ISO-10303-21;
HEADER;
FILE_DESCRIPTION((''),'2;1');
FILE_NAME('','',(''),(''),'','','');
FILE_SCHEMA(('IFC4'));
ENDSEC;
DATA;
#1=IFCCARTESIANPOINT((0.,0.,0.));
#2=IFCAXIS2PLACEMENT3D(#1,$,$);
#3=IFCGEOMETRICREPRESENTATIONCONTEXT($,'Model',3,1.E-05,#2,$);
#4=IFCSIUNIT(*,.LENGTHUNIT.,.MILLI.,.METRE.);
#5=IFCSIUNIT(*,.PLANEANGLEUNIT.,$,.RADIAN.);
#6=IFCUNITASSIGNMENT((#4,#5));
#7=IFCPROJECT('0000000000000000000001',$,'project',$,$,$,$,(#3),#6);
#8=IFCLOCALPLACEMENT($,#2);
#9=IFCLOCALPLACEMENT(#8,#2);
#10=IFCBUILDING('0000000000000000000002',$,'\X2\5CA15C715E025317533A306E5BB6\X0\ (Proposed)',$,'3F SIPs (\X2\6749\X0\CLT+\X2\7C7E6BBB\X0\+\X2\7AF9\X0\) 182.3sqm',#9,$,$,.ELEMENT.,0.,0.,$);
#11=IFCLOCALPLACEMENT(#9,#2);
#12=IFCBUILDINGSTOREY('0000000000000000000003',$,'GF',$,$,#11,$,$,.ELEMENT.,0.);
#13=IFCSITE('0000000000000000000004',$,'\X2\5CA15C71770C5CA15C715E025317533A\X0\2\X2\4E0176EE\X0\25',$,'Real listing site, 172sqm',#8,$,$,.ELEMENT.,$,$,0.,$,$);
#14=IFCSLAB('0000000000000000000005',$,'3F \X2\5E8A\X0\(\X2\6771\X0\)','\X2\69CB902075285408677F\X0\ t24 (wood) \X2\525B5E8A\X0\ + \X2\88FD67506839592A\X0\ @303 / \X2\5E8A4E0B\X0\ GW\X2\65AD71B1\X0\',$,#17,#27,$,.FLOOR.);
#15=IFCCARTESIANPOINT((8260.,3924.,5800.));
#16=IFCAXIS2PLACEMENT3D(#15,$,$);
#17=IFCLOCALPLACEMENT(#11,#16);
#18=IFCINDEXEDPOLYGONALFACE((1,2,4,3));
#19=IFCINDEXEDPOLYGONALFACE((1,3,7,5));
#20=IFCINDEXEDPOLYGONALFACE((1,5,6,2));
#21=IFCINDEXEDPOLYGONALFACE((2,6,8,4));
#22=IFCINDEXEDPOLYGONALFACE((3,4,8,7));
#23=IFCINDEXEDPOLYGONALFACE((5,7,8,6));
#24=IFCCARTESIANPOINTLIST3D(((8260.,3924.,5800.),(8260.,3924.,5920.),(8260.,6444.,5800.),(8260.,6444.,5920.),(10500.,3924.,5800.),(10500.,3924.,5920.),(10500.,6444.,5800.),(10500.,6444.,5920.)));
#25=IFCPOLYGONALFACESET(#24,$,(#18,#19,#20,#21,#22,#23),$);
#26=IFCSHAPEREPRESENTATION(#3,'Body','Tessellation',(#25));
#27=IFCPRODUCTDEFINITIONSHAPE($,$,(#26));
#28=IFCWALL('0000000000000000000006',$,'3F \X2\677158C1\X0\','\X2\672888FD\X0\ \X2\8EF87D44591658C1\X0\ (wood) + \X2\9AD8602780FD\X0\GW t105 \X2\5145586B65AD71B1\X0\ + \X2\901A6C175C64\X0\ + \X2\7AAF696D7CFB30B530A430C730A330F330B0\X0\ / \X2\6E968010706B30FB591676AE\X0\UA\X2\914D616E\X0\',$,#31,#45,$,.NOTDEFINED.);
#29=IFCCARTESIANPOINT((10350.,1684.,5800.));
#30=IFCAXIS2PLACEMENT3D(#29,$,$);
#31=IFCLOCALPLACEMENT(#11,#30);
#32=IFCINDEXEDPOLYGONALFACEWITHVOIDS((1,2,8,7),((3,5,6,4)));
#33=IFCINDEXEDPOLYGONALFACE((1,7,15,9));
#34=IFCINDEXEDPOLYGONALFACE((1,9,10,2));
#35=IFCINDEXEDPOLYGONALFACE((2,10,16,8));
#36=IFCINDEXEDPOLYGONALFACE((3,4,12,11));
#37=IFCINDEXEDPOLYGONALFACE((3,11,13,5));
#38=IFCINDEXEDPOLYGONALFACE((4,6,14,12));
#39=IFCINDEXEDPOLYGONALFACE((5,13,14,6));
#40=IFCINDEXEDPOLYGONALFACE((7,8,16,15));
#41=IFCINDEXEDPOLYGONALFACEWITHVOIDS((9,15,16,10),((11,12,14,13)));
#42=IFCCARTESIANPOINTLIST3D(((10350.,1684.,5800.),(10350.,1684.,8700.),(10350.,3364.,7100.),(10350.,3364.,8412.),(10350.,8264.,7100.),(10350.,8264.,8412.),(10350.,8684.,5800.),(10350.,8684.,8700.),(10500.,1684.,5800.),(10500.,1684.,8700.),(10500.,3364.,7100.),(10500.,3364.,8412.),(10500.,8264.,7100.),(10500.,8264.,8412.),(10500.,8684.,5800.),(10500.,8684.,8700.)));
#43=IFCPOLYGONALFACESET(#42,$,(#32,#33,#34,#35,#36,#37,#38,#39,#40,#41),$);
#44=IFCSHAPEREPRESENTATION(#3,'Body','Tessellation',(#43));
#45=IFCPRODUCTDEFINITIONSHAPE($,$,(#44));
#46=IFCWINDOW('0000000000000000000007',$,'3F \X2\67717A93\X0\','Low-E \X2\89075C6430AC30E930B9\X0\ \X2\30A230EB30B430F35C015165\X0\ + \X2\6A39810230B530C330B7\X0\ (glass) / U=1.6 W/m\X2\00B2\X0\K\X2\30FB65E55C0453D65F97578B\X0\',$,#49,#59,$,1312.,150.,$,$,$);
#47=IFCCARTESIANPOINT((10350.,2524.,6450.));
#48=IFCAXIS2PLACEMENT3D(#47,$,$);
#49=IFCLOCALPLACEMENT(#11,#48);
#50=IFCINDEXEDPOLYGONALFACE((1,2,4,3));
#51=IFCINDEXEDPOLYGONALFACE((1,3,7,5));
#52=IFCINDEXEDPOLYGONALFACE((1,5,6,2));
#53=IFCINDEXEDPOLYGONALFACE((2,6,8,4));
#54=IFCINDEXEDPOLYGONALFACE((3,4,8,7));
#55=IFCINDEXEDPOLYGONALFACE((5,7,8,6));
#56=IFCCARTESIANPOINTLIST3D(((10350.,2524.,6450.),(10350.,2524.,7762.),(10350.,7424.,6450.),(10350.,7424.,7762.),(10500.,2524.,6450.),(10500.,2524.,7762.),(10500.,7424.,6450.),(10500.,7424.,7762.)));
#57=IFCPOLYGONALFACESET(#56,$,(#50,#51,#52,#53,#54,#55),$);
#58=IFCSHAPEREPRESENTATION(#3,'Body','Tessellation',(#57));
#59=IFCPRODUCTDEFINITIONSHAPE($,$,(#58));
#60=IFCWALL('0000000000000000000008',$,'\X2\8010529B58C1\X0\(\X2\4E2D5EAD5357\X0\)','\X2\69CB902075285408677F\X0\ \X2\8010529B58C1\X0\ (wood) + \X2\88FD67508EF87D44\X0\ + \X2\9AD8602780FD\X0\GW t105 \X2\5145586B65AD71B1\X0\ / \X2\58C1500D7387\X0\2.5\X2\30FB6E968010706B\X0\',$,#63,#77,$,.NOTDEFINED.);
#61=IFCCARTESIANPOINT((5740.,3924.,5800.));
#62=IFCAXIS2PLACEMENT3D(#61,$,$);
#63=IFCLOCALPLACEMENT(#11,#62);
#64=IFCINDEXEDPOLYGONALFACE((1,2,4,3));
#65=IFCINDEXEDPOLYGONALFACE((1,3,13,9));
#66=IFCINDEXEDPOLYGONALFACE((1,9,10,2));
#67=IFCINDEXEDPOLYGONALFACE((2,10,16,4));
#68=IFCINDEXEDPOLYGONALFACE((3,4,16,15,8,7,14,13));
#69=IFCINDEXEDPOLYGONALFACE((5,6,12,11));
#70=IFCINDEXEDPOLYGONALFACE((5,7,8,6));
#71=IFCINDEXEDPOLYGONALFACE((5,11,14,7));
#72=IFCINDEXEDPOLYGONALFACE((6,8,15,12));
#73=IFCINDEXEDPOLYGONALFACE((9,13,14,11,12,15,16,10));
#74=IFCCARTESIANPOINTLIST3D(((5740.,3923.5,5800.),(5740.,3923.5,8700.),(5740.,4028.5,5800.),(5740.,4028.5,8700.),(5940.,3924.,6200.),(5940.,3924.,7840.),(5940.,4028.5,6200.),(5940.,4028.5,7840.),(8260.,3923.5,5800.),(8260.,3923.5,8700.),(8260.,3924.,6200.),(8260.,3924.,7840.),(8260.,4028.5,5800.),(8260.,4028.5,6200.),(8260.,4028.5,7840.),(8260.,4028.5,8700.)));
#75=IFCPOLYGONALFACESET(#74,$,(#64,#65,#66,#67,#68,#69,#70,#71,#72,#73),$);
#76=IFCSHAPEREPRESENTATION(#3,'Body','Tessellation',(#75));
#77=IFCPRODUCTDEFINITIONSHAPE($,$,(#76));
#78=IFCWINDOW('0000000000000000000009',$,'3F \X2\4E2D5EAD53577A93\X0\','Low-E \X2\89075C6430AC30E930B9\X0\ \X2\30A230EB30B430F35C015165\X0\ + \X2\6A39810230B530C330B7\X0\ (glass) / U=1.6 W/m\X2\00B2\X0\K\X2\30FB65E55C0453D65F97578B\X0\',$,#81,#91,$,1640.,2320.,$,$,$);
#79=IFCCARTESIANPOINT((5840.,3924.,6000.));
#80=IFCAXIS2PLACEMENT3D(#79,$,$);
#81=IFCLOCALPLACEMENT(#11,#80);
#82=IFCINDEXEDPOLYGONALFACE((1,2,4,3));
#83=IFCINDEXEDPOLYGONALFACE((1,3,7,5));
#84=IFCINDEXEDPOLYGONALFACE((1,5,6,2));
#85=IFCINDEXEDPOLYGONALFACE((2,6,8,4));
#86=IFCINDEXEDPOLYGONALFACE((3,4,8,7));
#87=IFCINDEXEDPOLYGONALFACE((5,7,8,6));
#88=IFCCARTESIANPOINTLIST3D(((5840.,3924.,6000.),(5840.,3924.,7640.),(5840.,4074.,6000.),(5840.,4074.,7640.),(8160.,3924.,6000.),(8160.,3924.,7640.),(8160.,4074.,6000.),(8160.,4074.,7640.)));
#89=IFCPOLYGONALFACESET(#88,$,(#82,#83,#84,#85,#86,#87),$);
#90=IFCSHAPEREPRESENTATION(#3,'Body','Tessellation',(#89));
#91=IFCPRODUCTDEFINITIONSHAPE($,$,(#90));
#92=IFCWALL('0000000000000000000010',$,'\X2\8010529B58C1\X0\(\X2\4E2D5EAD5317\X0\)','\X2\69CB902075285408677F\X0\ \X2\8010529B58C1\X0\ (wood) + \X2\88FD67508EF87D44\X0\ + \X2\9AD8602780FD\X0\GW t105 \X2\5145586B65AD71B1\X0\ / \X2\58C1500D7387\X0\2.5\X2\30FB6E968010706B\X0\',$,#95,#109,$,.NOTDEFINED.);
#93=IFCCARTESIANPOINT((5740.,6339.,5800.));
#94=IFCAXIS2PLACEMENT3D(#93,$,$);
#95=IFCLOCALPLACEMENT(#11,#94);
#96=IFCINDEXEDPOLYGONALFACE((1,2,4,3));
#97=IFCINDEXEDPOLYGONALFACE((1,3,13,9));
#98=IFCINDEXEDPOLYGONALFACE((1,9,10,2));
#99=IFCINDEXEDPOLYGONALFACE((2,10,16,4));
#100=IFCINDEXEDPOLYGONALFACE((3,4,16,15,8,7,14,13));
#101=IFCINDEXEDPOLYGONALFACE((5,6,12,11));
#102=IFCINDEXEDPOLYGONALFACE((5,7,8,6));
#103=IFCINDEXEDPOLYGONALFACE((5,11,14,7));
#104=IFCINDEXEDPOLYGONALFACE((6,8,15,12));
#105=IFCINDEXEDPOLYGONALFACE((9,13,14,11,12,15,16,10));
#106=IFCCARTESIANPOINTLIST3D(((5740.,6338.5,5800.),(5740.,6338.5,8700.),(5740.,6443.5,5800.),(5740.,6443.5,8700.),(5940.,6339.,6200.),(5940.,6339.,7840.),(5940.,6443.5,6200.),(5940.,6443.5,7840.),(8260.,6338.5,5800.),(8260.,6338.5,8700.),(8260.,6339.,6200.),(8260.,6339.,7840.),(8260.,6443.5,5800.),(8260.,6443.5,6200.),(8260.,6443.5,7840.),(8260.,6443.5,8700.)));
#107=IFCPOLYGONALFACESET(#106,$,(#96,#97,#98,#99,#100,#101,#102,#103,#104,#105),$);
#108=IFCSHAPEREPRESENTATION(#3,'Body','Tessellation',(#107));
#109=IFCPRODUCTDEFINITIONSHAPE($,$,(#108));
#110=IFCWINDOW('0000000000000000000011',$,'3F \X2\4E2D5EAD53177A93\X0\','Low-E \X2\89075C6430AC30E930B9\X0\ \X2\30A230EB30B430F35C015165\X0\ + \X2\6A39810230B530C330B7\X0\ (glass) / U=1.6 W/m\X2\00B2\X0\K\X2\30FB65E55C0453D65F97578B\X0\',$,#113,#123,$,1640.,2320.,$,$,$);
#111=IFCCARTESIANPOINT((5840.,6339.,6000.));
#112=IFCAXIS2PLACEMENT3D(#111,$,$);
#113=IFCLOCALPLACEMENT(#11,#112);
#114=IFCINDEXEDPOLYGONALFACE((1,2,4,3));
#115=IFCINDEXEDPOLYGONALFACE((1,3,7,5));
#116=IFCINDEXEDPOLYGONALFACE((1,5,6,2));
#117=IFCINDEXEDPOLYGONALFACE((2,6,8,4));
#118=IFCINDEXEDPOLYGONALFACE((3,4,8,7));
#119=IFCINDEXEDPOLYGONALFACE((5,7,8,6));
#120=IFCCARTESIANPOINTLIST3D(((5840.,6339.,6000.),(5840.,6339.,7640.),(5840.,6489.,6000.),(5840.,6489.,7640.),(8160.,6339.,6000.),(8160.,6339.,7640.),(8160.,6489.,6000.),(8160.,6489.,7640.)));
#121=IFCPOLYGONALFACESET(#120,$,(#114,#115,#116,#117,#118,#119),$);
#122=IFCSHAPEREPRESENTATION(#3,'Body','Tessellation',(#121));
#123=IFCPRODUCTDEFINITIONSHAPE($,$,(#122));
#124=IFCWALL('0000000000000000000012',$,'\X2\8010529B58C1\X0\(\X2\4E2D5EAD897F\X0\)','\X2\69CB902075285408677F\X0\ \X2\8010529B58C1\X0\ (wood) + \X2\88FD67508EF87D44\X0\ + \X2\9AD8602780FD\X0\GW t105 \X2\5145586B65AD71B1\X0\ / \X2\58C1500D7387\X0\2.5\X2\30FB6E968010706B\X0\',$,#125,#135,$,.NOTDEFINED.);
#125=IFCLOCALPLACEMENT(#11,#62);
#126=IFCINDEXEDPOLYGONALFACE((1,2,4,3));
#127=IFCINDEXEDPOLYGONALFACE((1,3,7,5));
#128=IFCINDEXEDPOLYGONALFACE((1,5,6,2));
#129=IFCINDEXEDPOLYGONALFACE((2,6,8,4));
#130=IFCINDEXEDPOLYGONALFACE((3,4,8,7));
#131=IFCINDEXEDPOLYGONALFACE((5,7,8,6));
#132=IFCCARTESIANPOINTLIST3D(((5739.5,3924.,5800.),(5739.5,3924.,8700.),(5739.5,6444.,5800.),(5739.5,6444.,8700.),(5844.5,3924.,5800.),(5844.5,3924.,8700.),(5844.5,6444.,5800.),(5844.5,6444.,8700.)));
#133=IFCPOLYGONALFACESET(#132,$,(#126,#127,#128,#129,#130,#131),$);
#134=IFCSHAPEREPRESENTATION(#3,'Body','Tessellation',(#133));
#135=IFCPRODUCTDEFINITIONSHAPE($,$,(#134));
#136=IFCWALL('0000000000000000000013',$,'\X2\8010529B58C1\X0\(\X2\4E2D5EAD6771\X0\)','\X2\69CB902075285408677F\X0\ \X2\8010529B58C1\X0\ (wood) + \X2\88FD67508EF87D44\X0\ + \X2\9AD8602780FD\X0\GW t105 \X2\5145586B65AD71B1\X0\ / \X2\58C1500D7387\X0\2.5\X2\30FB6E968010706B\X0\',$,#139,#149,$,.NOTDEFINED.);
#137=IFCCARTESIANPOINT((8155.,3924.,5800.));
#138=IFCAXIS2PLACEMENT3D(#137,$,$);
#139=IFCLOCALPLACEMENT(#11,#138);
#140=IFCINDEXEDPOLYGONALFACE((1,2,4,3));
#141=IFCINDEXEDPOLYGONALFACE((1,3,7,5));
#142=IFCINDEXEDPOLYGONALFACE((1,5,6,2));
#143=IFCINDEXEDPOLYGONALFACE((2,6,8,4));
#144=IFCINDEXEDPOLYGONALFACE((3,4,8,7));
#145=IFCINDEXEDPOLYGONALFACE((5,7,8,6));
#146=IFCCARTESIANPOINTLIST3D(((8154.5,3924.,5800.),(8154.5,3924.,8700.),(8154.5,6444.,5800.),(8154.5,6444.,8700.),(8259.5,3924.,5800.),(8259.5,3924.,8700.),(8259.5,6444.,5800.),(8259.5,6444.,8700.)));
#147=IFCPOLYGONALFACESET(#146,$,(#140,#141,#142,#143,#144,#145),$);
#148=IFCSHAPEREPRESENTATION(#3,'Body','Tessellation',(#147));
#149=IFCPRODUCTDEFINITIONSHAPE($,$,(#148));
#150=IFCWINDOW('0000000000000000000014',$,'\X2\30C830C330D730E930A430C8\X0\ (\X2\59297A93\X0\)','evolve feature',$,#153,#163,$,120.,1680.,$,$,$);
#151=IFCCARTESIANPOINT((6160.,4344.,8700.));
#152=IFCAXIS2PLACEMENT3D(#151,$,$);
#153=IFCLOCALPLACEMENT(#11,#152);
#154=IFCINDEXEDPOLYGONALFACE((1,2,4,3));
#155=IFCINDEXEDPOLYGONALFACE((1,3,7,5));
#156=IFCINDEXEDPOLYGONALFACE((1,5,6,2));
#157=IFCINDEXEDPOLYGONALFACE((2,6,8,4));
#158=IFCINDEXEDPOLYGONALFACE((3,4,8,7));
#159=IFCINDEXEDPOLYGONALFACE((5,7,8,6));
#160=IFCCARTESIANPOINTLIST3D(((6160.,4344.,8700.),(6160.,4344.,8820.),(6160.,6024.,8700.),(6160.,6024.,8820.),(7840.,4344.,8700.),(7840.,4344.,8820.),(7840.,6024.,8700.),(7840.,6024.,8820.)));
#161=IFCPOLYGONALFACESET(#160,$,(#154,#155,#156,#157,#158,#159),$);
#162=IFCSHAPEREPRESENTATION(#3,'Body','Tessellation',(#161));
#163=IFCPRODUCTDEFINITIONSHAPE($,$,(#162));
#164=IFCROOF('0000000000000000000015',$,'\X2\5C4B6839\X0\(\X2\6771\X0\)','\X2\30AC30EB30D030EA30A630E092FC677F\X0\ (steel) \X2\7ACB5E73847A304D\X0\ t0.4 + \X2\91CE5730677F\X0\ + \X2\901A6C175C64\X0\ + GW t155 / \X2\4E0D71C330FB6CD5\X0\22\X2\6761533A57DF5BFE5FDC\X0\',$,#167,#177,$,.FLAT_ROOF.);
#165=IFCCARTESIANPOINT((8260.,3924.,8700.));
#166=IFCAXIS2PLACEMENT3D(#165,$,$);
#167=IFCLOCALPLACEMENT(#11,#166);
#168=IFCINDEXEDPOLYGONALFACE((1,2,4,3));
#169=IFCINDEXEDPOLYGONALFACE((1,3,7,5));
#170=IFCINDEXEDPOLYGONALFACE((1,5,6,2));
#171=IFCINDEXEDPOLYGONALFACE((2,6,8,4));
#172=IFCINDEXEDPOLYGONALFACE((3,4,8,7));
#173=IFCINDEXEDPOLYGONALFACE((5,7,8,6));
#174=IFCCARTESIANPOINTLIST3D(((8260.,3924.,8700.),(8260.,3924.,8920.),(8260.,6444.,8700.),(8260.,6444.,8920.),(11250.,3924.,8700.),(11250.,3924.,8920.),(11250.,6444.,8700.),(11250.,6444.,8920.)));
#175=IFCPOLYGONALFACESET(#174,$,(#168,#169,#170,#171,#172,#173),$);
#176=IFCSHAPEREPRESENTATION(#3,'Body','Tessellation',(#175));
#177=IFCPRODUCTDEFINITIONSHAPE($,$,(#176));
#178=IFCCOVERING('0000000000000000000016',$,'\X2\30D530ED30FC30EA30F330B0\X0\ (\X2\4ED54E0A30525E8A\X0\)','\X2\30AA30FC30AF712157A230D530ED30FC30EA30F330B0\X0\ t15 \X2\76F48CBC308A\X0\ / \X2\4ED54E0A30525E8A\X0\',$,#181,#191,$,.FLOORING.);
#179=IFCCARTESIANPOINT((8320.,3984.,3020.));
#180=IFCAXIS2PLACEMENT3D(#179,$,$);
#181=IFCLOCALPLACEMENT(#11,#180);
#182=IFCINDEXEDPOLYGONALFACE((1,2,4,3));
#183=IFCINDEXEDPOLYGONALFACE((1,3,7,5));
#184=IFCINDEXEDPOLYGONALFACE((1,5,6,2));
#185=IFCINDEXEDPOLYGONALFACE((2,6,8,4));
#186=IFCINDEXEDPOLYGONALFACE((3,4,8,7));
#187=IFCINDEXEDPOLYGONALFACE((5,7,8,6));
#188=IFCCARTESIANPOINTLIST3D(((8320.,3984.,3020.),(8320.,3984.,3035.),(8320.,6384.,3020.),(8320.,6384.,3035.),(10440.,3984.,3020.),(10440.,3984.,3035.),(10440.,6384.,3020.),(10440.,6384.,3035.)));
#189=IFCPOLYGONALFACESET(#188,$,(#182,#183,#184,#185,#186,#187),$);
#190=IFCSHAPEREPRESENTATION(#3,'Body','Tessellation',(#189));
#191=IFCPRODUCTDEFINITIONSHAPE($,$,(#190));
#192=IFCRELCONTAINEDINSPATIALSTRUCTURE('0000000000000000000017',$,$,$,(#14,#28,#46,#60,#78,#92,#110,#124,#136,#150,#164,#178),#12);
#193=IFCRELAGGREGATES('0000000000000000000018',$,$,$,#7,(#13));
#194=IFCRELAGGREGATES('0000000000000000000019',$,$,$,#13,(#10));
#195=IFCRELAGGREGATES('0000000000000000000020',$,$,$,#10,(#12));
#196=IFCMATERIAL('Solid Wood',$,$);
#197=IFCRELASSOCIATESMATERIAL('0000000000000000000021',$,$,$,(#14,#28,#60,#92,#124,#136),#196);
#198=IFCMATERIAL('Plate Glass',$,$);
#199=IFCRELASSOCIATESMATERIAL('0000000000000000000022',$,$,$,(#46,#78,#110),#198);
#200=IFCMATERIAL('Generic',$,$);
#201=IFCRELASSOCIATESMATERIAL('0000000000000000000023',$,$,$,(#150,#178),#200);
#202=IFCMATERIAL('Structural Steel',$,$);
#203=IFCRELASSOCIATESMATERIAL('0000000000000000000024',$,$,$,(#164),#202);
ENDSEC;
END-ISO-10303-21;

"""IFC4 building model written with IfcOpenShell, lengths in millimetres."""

from ifc_helpers import new_model, si_unit, frame, frame_2d, origin, place, context, project, spatial, rectangle, extrude, material, element, fill, save


model = new_model("IFC4")

# Units and contexts
model_context = context("Model", 3, precision=1e-05, world=origin())
ifc_project = project(units=[si_unit("LENGTHUNIT", "METRE", prefix="MILLI"), si_unit("PLANEANGLEUNIT", "RADIAN")], contexts=[model_context])

# Site, building, storey
site_placement = place(None, origin())
site = spatial("IfcSite", under=ifc_project, at=site_placement, Name="岡山県岡山市北区2丁目25", ObjectType="Real listing site, 172sqm", CompositionType="ELEMENT", RefElevation=0.0)
building_placement = place(site_placement, origin())
building = spatial("IfcBuilding", under=site, at=building_placement, Name="岡山市北区の家 (Proposed)", ObjectType="3F SIPs (杉CLT+籾殻+竹) 182.3sqm", CompositionType="ELEMENT", ElevationOfRefHeight=0.0, ElevationOfTerrain=0.0)
storey_placement = place(building_placement, origin())
storey = spatial("IfcBuildingStorey", under=building, at=storey_placement, Name="GF", CompositionType="ELEMENT", Elevation=0.0)

# Slab
ifc_material_1 = material(Name="Solid Wood")
slab_placement = place(storey_placement, frame((8260.0, 3924.0, 5800.0)))
element("IfcSlab", 1, at=slab_placement, inside=storey, material=ifc_material_1, Name="3F 床(東)", Description="構造用合板 t24 (wood) 剛床 + 製材根太 @303 / 床下 GW断熱", PredefinedType="FLOOR", context=model_context, shape_type="SweptSolid", body=[
    extrude(rectangle(XDim=2240.0, YDim=2520.0, at=frame_2d((1120.0, 1260.0))), frame((8260.0, 3924.0, 5800.0)), (0.0, 0.0, 1.0), 120.0),
])

# Walls, openings, windows
wall_1_placement = place(storey_placement, frame((10350.0, 1684.0, 5800.0)))
wall_1 = element("IfcWall", 2, at=wall_1_placement, inside=storey, material=ifc_material_1, Name="3F 東壁", Description="木製 軸組外壁 (wood) + 高性能GW t105 充填断熱 + 通気層 + 窯業系サイディング / 準耐火・外皮UA配慮", PredefinedType="NOTDEFINED", context=model_context, shape_type="SweptSolid", body=[
    extrude(rectangle(XDim=150.0, YDim=7000.0, at=frame_2d((75.0, 3500.0))), frame((10350.0, 1684.0, 5800.0)), (0.0, 0.0, 1.0), 2900.0),
])
opening_1_placement = place(storey_placement, frame((10350.0, 2524.0, 6450.0)))
opening_1 = element("IfcOpeningElement", 3, at=opening_1_placement, cuts=wall_1, PredefinedType="NOTDEFINED", context=model_context, shape_type="SweptSolid", body=[
    extrude(rectangle(XDim=150.0, YDim=4900.0, at=frame_2d((75.0, 2450.0))), frame((10350.0, 2524.0, 6450.0)), (0.0, 0.0, 1.0), 1312.0),
])
ifc_material_2 = material(Name="Plate Glass")
window_1_placement = place(storey_placement, frame((10350.0, 2524.0, 6450.0)))
window_1 = element("IfcWindow", 4, at=window_1_placement, inside=storey, material=ifc_material_2, Name="3F 東窓", Description="Low-E 複層ガラス アルゴン封入 + 樹脂サッシ (glass) / U=1.6 W/m²K・日射取得型", OverallHeight=1312.0, OverallWidth=150.0, context=model_context, shape_type="SweptSolid", body=[
    extrude(rectangle(XDim=150.0, YDim=4900.0, at=frame_2d((75.0, 2450.0))), frame((10350.0, 2524.0, 6450.0)), (0.0, 0.0, 1.0), 1312.0),
])
fill(opening_1, window_1)
wall_2_placement = place(storey_placement, frame((5740.0, 3924.0, 5800.0)))
wall_2 = element("IfcWall", 5, at=wall_2_placement, inside=storey, material=ifc_material_1, Name="耐力壁(中庭南)", Description="構造用合板 耐力壁 (wood) + 製材軸組 + 高性能GW t105 充填断熱 / 壁倍率2.5・準耐火", PredefinedType="NOTDEFINED", context=model_context, shape_type="SweptSolid", body=[
    extrude(rectangle(XDim=2520.0, YDim=105.0, at=frame_2d((1260.0, 52.0))), frame((5740.0, 3924.0, 5800.0)), (0.0, 0.0, 1.0), 2900.0),
])
opening_2_placement = place(storey_placement, frame((5840.0, 3924.0, 6000.0)))
opening_2 = element("IfcOpeningElement", 6, at=opening_2_placement, cuts=wall_2, PredefinedType="NOTDEFINED", context=model_context, shape_type="SweptSolid", body=[
    extrude(rectangle(XDim=2320.0, YDim=150.0, at=frame_2d((1160.0, 75.0))), frame((5840.0, 3924.0, 6000.0)), (0.0, 0.0, 1.0), 1640.0),
])
window_2_placement = place(storey_placement, frame((5840.0, 3924.0, 6000.0)))
window_2 = element("IfcWindow", 7, at=window_2_placement, inside=storey, material=ifc_material_2, Name="3F 中庭南窓", Description="Low-E 複層ガラス アルゴン封入 + 樹脂サッシ (glass) / U=1.6 W/m²K・日射取得型", OverallHeight=1640.0, OverallWidth=2320.0, context=model_context, shape_type="SweptSolid", body=[
    extrude(rectangle(XDim=2320.0, YDim=150.0, at=frame_2d((1160.0, 75.0))), frame((5840.0, 3924.0, 6000.0)), (0.0, 0.0, 1.0), 1640.0),
])
fill(opening_2, window_2)
wall_3_placement = place(storey_placement, frame((5740.0, 6339.0, 5800.0)))
wall_3 = element("IfcWall", 8, at=wall_3_placement, inside=storey, material=ifc_material_1, Name="耐力壁(中庭北)", Description="構造用合板 耐力壁 (wood) + 製材軸組 + 高性能GW t105 充填断熱 / 壁倍率2.5・準耐火", PredefinedType="NOTDEFINED", context=model_context, shape_type="SweptSolid", body=[
    extrude(rectangle(XDim=2520.0, YDim=105.0, at=frame_2d((1260.0, 52.0))), frame((5740.0, 6339.0, 5800.0)), (0.0, 0.0, 1.0), 2900.0),
])
opening_3_placement = place(storey_placement, frame((5840.0, 6339.0, 6000.0)))
opening_3 = element("IfcOpeningElement", 9, at=opening_3_placement, cuts=wall_3, PredefinedType="NOTDEFINED", context=model_context, shape_type="SweptSolid", body=[
    extrude(rectangle(XDim=2320.0, YDim=150.0, at=frame_2d((1160.0, 75.0))), frame((5840.0, 6339.0, 6000.0)), (0.0, 0.0, 1.0), 1640.0),
])
window_3_placement = place(storey_placement, frame((5840.0, 6339.0, 6000.0)))
window_3 = element("IfcWindow", 10, at=window_3_placement, inside=storey, material=ifc_material_2, Name="3F 中庭北窓", Description="Low-E 複層ガラス アルゴン封入 + 樹脂サッシ (glass) / U=1.6 W/m²K・日射取得型", OverallHeight=1640.0, OverallWidth=2320.0, context=model_context, shape_type="SweptSolid", body=[
    extrude(rectangle(XDim=2320.0, YDim=150.0, at=frame_2d((1160.0, 75.0))), frame((5840.0, 6339.0, 6000.0)), (0.0, 0.0, 1.0), 1640.0),
])
fill(opening_3, window_3)

# Walls
wall_4_placement = place(storey_placement, frame((5740.0, 3924.0, 5800.0)))
element("IfcWall", 11, at=wall_4_placement, inside=storey, material=ifc_material_1, Name="耐力壁(中庭西)", Description="構造用合板 耐力壁 (wood) + 製材軸組 + 高性能GW t105 充填断熱 / 壁倍率2.5・準耐火", PredefinedType="NOTDEFINED", context=model_context, shape_type="SweptSolid", body=[
    extrude(rectangle(XDim=105.0, YDim=2520.0, at=frame_2d((52.0, 1260.0))), frame((5740.0, 3924.0, 5800.0)), (0.0, 0.0, 1.0), 2900.0),
])
wall_5_placement = place(storey_placement, frame((8155.0, 3924.0, 5800.0)))
element("IfcWall", 12, at=wall_5_placement, inside=storey, material=ifc_material_1, Name="耐力壁(中庭東)", Description="構造用合板 耐力壁 (wood) + 製材軸組 + 高性能GW t105 充填断熱 / 壁倍率2.5・準耐火", PredefinedType="NOTDEFINED", context=model_context, shape_type="SweptSolid", body=[
    extrude(rectangle(XDim=105.0, YDim=2520.0, at=frame_2d((52.0, 1260.0))), frame((8155.0, 3924.0, 5800.0)), (0.0, 0.0, 1.0), 2900.0),
])

# Window
ifc_material_3 = material(Name="Generic")
window_4_placement = place(storey_placement, frame((6160.0, 4344.0, 8700.0)))
element("IfcWindow", 13, at=window_4_placement, inside=storey, material=ifc_material_3, Name="トップライト (天窓)", Description="evolve feature", OverallHeight=120.0, OverallWidth=1680.0, context=model_context, shape_type="SweptSolid", body=[
    extrude(rectangle(XDim=1680.0, YDim=1680.0, at=frame_2d((840.0, 840.0))), frame((6160.0, 4344.0, 8700.0)), (0.0, 0.0, 1.0), 120.0),
])

# Roof
ifc_material_4 = material(Name="Structural Steel")
for number, where, name in (
    (14, (8260.0, 3924.0, 8700.0), "屋根(東)"),
):
    element("IfcRoof", number, at=place(storey_placement, frame(where)), inside=storey, material=ifc_material_4, Name=name, Description="ガルバリウム鋼板 (steel) 立平葺き t0.4 + 野地板 + 通気層 + GW t155 / 不燃・法22条区域対応", PredefinedType="FLAT_ROOF", context=model_context, shape_type="SweptSolid", body=[
        extrude(rectangle(XDim=2990.0, YDim=2520.0, at=frame_2d((1495.0, 1260.0))), frame((8260.0, 3924.0, 8700.0)), (0.0, 0.0, 1.0), 220.0),
    ])

# Covering
covering_1_placement = place(storey_placement, frame((8320.0, 3984.0, 3020.0)))
element("IfcCovering", 15, at=covering_1_placement, inside=storey, material=ifc_material_3, Name="フローリング (仕上げ床)", Description="オーク無垢フローリング t15 直貼り / 仕上げ床", PredefinedType="FLOORING", context=model_context, shape_type="SweptSolid", body=[
    extrude(rectangle(XDim=2120.0, YDim=2400.0, at=frame_2d((1060.0, 1200.0))), frame((8320.0, 3984.0, 3020.0)), (0.0, 0.0, 1.0), 15.0),
])

save(model, "model.ifc")
